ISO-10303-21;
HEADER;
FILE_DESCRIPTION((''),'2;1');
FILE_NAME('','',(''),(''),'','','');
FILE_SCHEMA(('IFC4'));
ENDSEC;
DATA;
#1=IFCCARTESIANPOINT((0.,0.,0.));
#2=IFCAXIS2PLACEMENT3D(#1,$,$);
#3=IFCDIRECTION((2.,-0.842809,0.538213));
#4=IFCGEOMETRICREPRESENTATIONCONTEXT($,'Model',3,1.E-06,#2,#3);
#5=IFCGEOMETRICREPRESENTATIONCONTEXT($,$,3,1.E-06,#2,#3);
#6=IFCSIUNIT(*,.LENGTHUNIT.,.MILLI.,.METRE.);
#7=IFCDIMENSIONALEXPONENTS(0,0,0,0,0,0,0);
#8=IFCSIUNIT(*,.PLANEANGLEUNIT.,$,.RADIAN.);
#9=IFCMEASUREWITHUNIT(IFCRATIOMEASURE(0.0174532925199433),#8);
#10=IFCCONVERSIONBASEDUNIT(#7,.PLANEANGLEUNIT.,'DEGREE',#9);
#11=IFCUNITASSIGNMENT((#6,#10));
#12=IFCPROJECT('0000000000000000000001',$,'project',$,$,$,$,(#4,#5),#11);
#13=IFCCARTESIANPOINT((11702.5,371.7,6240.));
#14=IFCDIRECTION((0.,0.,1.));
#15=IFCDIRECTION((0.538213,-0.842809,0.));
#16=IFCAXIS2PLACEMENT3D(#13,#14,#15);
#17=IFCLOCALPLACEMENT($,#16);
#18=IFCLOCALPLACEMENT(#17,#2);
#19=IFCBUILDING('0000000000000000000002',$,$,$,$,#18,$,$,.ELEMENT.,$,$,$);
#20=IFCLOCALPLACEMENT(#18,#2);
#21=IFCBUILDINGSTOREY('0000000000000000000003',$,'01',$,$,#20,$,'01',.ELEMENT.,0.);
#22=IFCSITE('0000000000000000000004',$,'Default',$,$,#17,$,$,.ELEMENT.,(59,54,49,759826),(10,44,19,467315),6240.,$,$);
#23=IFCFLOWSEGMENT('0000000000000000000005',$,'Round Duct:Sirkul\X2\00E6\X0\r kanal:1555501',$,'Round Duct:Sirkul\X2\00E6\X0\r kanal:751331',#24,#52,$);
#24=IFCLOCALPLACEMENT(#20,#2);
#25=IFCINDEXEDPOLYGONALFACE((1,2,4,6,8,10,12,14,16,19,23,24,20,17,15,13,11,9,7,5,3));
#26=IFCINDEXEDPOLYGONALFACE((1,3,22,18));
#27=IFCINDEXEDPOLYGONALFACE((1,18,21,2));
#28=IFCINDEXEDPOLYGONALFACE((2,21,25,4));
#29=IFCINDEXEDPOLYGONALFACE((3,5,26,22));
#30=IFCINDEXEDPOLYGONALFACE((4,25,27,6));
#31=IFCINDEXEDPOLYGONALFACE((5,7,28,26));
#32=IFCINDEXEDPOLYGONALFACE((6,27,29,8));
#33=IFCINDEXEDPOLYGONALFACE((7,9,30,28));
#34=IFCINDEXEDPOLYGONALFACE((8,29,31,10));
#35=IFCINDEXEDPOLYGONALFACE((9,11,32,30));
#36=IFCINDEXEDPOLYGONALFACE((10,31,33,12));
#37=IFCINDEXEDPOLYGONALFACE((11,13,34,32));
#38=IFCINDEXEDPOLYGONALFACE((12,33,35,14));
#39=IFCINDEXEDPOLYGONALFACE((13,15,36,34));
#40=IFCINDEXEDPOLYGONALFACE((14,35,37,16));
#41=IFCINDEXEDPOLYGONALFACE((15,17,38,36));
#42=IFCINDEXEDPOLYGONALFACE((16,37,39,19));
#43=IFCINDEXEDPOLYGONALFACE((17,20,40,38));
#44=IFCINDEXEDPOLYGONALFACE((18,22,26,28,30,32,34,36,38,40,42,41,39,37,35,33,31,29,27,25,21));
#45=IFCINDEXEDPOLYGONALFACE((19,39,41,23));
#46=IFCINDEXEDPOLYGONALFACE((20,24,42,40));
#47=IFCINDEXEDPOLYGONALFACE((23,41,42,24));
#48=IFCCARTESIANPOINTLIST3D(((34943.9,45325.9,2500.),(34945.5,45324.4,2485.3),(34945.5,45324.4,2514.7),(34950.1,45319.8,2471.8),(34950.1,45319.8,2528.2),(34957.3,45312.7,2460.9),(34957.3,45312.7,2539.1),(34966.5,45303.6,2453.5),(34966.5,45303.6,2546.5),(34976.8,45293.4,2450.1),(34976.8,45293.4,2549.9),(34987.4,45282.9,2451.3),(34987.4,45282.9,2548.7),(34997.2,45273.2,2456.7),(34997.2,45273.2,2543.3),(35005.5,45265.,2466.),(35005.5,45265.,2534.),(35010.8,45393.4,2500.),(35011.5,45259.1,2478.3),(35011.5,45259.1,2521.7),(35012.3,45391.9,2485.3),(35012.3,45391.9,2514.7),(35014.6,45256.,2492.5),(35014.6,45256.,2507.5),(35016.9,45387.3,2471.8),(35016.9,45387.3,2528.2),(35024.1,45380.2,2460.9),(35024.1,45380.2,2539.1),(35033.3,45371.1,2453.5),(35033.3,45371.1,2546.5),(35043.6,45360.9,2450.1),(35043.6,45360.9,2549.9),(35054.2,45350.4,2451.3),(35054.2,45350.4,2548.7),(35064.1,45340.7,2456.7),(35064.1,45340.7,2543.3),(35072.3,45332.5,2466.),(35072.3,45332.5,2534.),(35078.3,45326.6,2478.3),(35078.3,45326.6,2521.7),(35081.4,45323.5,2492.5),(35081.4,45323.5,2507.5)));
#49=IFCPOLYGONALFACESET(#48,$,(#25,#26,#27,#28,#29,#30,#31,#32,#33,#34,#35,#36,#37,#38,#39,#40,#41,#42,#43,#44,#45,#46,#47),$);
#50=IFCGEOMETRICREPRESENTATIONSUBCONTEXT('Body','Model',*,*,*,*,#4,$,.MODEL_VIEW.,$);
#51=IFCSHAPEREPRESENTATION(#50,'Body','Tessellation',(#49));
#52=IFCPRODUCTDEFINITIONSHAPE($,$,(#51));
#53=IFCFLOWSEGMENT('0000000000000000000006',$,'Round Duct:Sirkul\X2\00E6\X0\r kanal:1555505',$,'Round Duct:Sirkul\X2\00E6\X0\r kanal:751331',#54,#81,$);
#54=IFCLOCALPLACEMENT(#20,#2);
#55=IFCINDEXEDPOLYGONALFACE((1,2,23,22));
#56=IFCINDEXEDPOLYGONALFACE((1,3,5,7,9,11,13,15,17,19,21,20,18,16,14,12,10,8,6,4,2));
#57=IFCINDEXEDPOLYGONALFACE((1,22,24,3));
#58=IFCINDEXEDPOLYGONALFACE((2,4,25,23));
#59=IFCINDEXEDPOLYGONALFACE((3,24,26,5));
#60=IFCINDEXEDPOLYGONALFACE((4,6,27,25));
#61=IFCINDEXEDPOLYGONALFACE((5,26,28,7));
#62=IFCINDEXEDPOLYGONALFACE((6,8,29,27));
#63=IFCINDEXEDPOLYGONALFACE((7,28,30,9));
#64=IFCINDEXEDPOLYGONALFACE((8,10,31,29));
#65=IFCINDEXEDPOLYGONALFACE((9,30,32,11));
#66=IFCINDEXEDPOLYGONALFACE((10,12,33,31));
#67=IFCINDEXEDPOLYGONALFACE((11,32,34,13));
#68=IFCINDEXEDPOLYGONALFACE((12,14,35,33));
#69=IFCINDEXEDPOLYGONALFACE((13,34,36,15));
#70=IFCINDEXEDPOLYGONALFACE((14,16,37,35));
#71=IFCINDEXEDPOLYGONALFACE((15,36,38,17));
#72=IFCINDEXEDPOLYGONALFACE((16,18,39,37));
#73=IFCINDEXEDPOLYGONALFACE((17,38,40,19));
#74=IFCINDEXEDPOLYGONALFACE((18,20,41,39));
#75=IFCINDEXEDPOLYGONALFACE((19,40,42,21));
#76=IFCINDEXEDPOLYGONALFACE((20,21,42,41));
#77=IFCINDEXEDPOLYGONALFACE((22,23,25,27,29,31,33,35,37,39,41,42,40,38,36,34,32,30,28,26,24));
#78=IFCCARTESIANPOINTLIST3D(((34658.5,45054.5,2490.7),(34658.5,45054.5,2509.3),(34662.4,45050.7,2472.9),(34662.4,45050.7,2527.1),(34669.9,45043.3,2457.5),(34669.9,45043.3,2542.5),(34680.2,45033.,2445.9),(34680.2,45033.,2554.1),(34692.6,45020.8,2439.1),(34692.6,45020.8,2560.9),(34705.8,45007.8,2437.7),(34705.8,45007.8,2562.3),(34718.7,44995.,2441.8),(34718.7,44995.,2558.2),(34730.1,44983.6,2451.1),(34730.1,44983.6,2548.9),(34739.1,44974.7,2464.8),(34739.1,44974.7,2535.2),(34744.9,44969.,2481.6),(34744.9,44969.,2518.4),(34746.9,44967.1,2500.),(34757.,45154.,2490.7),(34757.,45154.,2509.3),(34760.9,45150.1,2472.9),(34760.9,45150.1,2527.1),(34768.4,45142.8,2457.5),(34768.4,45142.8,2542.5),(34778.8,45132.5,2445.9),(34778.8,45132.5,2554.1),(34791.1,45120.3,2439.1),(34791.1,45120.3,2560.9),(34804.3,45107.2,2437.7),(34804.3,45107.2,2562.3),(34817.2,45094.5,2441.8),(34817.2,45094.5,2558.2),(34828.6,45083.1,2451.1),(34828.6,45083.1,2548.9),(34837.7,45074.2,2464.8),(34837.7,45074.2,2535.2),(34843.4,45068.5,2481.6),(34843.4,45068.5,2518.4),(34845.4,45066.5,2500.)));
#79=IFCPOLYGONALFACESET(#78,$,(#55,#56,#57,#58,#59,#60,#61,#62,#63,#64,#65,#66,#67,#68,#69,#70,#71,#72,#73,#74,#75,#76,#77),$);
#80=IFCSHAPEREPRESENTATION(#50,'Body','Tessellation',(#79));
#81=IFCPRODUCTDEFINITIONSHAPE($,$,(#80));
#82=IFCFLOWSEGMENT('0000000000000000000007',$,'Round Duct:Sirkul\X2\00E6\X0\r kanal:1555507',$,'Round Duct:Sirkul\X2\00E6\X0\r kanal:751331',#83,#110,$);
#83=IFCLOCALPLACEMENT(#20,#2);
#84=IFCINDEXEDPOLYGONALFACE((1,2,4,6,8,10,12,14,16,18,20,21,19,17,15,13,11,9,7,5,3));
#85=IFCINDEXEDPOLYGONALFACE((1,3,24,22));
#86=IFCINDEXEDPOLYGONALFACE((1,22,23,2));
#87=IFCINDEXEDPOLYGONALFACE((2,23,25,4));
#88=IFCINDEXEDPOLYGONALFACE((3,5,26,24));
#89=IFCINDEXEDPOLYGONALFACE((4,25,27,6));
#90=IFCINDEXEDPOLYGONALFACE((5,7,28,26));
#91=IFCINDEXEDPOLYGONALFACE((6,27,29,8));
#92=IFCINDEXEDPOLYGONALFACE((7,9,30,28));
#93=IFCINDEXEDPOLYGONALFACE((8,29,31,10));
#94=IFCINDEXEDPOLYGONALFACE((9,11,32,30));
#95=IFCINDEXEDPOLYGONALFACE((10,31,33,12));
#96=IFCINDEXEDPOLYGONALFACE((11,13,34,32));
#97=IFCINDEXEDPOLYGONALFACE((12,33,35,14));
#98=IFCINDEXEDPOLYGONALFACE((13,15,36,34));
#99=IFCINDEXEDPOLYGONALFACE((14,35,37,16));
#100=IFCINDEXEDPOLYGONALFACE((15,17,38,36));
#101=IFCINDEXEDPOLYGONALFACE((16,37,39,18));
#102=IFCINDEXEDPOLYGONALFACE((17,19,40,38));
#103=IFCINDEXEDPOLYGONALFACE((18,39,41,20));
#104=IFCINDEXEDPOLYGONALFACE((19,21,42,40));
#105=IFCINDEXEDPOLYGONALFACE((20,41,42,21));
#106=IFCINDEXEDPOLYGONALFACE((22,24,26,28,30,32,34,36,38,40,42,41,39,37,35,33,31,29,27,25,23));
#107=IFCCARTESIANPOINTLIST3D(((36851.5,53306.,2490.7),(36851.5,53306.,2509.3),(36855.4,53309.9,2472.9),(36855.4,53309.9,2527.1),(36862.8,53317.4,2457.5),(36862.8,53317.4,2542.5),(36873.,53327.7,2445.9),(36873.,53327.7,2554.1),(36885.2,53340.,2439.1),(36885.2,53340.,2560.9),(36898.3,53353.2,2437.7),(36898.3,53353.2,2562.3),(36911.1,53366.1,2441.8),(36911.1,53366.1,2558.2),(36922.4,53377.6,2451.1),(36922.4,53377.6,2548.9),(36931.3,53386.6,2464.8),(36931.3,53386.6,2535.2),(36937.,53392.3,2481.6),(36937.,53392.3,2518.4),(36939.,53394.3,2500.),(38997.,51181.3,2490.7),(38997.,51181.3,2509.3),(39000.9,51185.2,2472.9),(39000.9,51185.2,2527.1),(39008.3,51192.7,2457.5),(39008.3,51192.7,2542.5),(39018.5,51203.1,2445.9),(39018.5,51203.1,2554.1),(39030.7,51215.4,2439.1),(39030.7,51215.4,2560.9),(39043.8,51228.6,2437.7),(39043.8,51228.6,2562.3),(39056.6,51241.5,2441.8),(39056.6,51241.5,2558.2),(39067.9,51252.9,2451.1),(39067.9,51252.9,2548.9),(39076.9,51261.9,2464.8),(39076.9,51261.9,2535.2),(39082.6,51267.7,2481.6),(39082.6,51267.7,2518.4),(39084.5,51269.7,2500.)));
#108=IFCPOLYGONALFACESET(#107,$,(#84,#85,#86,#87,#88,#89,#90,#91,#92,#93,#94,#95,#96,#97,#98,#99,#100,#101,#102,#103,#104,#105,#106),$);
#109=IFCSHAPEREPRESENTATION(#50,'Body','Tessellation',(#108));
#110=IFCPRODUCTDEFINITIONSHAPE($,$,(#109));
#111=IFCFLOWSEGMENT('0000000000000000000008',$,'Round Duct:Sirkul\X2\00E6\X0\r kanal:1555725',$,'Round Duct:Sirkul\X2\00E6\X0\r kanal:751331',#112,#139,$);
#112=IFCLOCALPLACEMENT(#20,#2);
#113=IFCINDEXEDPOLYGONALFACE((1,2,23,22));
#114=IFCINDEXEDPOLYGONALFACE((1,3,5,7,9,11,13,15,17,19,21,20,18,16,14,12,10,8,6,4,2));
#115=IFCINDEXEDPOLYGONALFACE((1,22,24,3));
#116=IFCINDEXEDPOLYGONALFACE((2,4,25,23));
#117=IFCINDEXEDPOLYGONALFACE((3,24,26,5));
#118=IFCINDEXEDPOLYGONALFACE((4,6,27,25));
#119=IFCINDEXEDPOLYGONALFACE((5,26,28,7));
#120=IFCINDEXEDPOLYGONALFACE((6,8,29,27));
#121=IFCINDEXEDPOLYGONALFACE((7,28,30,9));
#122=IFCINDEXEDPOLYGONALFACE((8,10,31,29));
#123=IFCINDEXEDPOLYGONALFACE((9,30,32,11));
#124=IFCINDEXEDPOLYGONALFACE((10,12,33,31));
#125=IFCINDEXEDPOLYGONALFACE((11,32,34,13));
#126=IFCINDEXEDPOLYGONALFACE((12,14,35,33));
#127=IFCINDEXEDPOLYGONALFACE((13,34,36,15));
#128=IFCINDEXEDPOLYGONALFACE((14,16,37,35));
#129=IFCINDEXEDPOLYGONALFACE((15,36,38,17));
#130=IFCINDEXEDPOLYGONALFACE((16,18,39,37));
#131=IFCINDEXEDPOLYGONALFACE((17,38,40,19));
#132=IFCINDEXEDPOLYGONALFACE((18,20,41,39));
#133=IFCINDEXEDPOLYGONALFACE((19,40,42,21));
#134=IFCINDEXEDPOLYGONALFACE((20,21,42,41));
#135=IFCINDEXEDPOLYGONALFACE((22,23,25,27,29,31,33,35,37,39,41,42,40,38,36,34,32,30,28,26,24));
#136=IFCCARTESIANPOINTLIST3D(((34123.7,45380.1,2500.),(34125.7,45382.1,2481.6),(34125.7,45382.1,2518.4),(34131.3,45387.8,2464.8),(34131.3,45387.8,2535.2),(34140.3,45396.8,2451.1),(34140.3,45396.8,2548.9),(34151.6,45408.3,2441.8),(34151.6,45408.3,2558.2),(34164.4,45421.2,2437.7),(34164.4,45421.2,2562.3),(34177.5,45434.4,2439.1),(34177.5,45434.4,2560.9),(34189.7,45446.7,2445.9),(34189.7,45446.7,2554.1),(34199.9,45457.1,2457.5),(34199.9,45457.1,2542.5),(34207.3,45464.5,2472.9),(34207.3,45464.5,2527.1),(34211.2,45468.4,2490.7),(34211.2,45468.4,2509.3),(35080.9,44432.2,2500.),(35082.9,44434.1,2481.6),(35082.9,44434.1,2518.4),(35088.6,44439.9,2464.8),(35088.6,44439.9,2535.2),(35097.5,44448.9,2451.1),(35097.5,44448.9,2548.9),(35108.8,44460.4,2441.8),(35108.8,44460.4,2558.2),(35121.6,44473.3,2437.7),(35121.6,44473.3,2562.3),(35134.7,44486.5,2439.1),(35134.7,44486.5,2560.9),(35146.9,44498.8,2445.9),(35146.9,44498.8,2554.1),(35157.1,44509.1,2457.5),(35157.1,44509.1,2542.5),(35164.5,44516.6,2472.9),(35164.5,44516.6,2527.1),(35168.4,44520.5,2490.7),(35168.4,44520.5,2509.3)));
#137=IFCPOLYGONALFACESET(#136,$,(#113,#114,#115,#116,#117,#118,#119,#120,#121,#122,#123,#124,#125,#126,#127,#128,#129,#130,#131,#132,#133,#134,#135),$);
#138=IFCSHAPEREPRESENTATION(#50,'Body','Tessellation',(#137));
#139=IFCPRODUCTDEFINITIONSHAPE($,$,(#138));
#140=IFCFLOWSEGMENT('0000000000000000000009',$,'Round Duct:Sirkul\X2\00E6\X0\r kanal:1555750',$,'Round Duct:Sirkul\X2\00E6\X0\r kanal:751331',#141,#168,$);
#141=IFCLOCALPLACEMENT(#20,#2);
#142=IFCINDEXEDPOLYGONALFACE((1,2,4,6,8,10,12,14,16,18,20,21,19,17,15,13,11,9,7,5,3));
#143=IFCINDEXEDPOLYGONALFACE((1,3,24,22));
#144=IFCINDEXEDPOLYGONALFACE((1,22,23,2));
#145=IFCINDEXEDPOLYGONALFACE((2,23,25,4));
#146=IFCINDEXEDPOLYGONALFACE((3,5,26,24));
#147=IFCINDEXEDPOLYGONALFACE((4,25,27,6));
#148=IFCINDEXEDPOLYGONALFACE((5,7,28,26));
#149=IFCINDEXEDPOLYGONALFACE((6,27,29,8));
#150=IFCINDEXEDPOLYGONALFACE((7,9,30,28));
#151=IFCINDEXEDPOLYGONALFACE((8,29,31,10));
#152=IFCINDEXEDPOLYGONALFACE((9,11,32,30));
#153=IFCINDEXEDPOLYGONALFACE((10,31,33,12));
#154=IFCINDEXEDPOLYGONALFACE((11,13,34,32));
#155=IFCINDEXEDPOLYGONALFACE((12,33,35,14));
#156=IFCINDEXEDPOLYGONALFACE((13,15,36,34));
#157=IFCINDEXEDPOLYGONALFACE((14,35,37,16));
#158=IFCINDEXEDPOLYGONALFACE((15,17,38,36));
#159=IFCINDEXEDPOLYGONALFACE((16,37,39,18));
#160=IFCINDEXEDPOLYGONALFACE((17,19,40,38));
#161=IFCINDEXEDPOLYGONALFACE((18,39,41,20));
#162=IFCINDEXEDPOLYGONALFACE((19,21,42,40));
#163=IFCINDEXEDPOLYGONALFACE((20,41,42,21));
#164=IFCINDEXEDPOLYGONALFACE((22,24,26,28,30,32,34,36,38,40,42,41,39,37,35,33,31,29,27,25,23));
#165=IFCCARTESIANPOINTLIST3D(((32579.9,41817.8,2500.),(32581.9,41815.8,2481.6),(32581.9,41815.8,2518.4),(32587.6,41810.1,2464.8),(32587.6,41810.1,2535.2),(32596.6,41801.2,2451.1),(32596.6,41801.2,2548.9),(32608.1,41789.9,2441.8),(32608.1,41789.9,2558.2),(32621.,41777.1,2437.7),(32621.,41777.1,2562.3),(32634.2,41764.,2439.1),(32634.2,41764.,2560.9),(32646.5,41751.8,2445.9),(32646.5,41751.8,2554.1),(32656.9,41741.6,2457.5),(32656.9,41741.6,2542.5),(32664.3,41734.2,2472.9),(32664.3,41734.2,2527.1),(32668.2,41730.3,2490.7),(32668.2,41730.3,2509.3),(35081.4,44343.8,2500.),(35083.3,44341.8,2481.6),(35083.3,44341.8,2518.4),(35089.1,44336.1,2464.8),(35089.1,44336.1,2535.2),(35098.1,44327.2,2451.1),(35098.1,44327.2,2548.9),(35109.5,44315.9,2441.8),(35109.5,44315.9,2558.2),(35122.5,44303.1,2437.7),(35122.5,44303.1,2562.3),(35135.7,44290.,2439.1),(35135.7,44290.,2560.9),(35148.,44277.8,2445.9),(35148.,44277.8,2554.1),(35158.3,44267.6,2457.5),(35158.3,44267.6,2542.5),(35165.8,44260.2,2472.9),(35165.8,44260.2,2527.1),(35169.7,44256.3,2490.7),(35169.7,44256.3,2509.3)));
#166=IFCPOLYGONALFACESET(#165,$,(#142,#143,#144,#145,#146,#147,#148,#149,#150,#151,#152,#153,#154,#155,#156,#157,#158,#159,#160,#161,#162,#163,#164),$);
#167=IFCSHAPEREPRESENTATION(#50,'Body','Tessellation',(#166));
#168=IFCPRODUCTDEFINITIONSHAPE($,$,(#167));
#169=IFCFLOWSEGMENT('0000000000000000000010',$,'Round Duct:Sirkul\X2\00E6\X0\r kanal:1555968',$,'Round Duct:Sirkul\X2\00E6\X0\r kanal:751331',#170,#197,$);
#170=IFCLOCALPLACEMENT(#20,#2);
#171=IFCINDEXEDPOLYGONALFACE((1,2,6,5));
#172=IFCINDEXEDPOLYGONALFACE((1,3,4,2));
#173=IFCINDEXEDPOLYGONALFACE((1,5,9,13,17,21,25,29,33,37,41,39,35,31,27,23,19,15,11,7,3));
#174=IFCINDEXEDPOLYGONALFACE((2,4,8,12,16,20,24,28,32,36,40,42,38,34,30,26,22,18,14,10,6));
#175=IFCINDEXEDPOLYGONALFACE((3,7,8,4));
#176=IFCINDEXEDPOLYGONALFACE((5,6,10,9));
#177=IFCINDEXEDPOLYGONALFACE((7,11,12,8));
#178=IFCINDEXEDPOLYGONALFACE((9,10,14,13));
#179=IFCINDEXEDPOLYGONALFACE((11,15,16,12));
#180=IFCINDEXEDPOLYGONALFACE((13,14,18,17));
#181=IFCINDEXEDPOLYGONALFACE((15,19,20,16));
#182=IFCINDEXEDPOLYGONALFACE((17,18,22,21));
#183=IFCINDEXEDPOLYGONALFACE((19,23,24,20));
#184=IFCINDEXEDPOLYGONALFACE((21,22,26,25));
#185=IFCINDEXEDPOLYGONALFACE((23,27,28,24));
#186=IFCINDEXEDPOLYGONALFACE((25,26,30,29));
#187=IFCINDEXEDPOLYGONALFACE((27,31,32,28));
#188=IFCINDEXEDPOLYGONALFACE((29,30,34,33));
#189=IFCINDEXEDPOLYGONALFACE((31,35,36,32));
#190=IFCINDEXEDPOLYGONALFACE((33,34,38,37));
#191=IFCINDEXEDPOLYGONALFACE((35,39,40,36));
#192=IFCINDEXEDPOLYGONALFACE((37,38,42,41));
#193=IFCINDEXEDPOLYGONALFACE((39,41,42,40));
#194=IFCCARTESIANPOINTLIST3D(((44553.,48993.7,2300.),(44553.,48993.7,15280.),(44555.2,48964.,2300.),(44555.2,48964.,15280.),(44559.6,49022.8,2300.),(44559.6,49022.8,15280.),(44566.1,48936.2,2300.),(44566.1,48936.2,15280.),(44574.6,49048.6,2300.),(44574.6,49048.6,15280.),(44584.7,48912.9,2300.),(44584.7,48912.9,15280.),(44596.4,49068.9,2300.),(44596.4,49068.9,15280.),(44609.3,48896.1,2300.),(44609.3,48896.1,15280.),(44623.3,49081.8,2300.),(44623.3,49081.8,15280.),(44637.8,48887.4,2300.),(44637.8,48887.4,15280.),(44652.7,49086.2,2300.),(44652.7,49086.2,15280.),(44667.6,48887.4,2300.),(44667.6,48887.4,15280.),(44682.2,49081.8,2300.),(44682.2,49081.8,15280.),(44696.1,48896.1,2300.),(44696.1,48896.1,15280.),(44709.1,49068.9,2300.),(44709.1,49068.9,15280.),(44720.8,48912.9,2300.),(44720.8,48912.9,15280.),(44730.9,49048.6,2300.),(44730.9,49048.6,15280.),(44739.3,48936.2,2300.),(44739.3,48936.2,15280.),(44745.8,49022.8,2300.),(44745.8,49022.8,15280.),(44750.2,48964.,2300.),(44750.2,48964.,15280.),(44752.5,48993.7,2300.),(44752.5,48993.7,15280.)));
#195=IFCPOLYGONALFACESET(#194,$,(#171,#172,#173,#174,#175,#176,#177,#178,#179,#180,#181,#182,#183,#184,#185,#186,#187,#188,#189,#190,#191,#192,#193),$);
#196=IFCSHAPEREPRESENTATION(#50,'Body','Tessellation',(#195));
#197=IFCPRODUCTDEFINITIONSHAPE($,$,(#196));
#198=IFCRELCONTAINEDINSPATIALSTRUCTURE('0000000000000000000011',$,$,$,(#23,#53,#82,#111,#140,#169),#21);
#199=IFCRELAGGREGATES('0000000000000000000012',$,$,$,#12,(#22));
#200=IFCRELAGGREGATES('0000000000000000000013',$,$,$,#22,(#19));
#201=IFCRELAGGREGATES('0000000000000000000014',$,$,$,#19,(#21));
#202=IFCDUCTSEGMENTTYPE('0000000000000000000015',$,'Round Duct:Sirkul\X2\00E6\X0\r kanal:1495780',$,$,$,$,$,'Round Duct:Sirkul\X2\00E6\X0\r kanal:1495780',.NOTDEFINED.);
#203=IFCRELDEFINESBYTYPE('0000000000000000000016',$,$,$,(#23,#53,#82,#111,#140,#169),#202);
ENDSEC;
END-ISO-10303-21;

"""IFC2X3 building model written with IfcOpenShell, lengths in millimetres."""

from ifc_helpers import new_model, entity, si_unit, converted_unit, direction, frame, origin, origin_2d_with_axis, place, context, subcontext, project, spatial, circle, extrude, type_object, element, save


model = new_model("IFC2X3")

# Units and contexts
model_context = context("Model", 3, precision=1e-06, world=origin(), true_north=direction((2.0, -0.842809, 0.538213)))
context_of_model = context(None, 3, precision=1e-06, world=origin(), true_north=direction((2.0, -0.842809, 0.538213)))
body_context = subcontext(model_context, "Body", "Model", "MODEL_VIEW")
ifc_project = project(units=[si_unit("LENGTHUNIT", "METRE", prefix="MILLI"), converted_unit("PLANEANGLEUNIT", "DEGREE", entity("IfcRatioMeasure", 0.0174532925199433), si_unit("PLANEANGLEUNIT", "RADIAN"), dimensions=[0, 0, 0, 0, 0, 0, 0])], contexts=[model_context, context_of_model])

# Site, building, storey
site_placement = place(None, frame((11702.5, 371.7, 6240.0), z_axis=(0.0, 0.0, 1.0), x_axis=(0.538213, -0.842809, 0.0)))
site = spatial("IfcSite", under=ifc_project, at=site_placement, Name="Default", CompositionType="ELEMENT", RefLatitude=(59, 54, 49, 759826), RefLongitude=(10, 44, 19, 467315), RefElevation=6240.0)
building_placement = place(site_placement, origin())
building = spatial("IfcBuilding", under=site, at=building_placement, CompositionType="ELEMENT")
storey_placement = place(building_placement, origin())
storey = spatial("IfcBuildingStorey", under=building, at=storey_placement, Name="01", LongName="01", CompositionType="ELEMENT", Elevation=0.0)

# Flow segments
duct_segment_type = type_object("IfcDuctSegmentType", Name="Round Duct:Sirkulær kanal:1495780", ElementType="Round Duct:Sirkulær kanal:1495780", PredefinedType="NOTDEFINED")
flow_segment_1_placement = place(storey_placement, origin())
element("IfcFlowSegment", 1, at=flow_segment_1_placement, inside=storey, type_object=duct_segment_type, Name="Round Duct:Sirkulær kanal:1555501", ObjectType="Round Duct:Sirkulær kanal:751331", context=body_context, shape_type="SweptSolid", body=[
    extrude(circle(Radius=50.0, at=origin_2d_with_axis()), frame((34979.4, 45290.8, 2500.0), z_axis=(0.703643, 0.710554, 0.0), x_axis=(-0.710554, 0.703643, 0.0)), (0.0, 0.0, 1.0), 95.0),
])
flow_segment_2_placement = place(storey_placement, origin())
element("IfcFlowSegment", 2, at=flow_segment_2_placement, inside=storey, type_object=duct_segment_type, Name="Round Duct:Sirkulær kanal:1555505", ObjectType="Round Duct:Sirkulær kanal:751331", context=body_context, shape_type="SweptSolid", body=[
    extrude(circle(Radius=62.5, at=origin_2d_with_axis()), frame((34702.4, 45011.0, 2500.0), z_axis=(0.703643, 0.710554, 0.0), x_axis=(0.710554, -0.703643, 0.0)), (0.0, 0.0, 1.0), 140.0),
])
flow_segment_3_placement = place(storey_placement, origin())
element("IfcFlowSegment", 3, at=flow_segment_3_placement, inside=storey, type_object=duct_segment_type, Name="Round Duct:Sirkulær kanal:1555507", ObjectType="Round Duct:Sirkulær kanal:751331", context=body_context, shape_type="SweptSolid", body=[
    extrude(circle(Radius=62.5, at=origin_2d_with_axis()), frame((39040.5, 51225.3, 2500.0), z_axis=(-0.710554, 0.703643, 0.0), x_axis=(0.703643, 0.710554, 0.0)), (0.0, 0.0, 1.0), 3019.5),
])
flow_segment_4_placement = place(storey_placement, origin())
element("IfcFlowSegment", 4, at=flow_segment_4_placement, inside=storey, type_object=duct_segment_type, Name="Round Duct:Sirkulær kanal:1555725", ObjectType="Round Duct:Sirkulær kanal:751331", context=body_context, shape_type="SweptSolid", body=[
    extrude(circle(Radius=62.5, at=origin_2d_with_axis()), frame((35124.9, 44476.6, 2500.0), z_axis=(-0.710554, 0.703643, 0.0), x_axis=(-0.703643, -0.710554, 0.0)), (0.0, 0.0, 1.0), 1347.2),
])
flow_segment_5_placement = place(storey_placement, origin())
element("IfcFlowSegment", 5, at=flow_segment_5_placement, inside=storey, type_object=duct_segment_type, Name="Round Duct:Sirkulær kanal:1555750", ObjectType="Round Duct:Sirkulær kanal:751331", context=body_context, shape_type="SweptSolid", body=[
    extrude(circle(Radius=62.5, at=origin_2d_with_axis()), frame((32624.3, 41773.8, 2500.0), z_axis=(0.703643, 0.710554, 0.0), x_axis=(-0.710554, 0.703643, 0.0)), (0.0, 0.0, 1.0), 3555.0),
])
flow_segment_6_placement = place(storey_placement, origin())
element("IfcFlowSegment", 6, at=flow_segment_6_placement, inside=storey, type_object=duct_segment_type, Name="Round Duct:Sirkulær kanal:1555968", ObjectType="Round Duct:Sirkulær kanal:751331", context=body_context, shape_type="SweptSolid", body=[
    extrude(circle(Radius=100.0, at=origin_2d_with_axis()), frame((44652.7, 48986.2, 2300.0), z_axis=(0.0, 0.0, 1.0), x_axis=(0.0, 1.0, 0.0)), (0.0, 0.0, 1.0), 12980.0),
])

save(model, "model.ifc")
